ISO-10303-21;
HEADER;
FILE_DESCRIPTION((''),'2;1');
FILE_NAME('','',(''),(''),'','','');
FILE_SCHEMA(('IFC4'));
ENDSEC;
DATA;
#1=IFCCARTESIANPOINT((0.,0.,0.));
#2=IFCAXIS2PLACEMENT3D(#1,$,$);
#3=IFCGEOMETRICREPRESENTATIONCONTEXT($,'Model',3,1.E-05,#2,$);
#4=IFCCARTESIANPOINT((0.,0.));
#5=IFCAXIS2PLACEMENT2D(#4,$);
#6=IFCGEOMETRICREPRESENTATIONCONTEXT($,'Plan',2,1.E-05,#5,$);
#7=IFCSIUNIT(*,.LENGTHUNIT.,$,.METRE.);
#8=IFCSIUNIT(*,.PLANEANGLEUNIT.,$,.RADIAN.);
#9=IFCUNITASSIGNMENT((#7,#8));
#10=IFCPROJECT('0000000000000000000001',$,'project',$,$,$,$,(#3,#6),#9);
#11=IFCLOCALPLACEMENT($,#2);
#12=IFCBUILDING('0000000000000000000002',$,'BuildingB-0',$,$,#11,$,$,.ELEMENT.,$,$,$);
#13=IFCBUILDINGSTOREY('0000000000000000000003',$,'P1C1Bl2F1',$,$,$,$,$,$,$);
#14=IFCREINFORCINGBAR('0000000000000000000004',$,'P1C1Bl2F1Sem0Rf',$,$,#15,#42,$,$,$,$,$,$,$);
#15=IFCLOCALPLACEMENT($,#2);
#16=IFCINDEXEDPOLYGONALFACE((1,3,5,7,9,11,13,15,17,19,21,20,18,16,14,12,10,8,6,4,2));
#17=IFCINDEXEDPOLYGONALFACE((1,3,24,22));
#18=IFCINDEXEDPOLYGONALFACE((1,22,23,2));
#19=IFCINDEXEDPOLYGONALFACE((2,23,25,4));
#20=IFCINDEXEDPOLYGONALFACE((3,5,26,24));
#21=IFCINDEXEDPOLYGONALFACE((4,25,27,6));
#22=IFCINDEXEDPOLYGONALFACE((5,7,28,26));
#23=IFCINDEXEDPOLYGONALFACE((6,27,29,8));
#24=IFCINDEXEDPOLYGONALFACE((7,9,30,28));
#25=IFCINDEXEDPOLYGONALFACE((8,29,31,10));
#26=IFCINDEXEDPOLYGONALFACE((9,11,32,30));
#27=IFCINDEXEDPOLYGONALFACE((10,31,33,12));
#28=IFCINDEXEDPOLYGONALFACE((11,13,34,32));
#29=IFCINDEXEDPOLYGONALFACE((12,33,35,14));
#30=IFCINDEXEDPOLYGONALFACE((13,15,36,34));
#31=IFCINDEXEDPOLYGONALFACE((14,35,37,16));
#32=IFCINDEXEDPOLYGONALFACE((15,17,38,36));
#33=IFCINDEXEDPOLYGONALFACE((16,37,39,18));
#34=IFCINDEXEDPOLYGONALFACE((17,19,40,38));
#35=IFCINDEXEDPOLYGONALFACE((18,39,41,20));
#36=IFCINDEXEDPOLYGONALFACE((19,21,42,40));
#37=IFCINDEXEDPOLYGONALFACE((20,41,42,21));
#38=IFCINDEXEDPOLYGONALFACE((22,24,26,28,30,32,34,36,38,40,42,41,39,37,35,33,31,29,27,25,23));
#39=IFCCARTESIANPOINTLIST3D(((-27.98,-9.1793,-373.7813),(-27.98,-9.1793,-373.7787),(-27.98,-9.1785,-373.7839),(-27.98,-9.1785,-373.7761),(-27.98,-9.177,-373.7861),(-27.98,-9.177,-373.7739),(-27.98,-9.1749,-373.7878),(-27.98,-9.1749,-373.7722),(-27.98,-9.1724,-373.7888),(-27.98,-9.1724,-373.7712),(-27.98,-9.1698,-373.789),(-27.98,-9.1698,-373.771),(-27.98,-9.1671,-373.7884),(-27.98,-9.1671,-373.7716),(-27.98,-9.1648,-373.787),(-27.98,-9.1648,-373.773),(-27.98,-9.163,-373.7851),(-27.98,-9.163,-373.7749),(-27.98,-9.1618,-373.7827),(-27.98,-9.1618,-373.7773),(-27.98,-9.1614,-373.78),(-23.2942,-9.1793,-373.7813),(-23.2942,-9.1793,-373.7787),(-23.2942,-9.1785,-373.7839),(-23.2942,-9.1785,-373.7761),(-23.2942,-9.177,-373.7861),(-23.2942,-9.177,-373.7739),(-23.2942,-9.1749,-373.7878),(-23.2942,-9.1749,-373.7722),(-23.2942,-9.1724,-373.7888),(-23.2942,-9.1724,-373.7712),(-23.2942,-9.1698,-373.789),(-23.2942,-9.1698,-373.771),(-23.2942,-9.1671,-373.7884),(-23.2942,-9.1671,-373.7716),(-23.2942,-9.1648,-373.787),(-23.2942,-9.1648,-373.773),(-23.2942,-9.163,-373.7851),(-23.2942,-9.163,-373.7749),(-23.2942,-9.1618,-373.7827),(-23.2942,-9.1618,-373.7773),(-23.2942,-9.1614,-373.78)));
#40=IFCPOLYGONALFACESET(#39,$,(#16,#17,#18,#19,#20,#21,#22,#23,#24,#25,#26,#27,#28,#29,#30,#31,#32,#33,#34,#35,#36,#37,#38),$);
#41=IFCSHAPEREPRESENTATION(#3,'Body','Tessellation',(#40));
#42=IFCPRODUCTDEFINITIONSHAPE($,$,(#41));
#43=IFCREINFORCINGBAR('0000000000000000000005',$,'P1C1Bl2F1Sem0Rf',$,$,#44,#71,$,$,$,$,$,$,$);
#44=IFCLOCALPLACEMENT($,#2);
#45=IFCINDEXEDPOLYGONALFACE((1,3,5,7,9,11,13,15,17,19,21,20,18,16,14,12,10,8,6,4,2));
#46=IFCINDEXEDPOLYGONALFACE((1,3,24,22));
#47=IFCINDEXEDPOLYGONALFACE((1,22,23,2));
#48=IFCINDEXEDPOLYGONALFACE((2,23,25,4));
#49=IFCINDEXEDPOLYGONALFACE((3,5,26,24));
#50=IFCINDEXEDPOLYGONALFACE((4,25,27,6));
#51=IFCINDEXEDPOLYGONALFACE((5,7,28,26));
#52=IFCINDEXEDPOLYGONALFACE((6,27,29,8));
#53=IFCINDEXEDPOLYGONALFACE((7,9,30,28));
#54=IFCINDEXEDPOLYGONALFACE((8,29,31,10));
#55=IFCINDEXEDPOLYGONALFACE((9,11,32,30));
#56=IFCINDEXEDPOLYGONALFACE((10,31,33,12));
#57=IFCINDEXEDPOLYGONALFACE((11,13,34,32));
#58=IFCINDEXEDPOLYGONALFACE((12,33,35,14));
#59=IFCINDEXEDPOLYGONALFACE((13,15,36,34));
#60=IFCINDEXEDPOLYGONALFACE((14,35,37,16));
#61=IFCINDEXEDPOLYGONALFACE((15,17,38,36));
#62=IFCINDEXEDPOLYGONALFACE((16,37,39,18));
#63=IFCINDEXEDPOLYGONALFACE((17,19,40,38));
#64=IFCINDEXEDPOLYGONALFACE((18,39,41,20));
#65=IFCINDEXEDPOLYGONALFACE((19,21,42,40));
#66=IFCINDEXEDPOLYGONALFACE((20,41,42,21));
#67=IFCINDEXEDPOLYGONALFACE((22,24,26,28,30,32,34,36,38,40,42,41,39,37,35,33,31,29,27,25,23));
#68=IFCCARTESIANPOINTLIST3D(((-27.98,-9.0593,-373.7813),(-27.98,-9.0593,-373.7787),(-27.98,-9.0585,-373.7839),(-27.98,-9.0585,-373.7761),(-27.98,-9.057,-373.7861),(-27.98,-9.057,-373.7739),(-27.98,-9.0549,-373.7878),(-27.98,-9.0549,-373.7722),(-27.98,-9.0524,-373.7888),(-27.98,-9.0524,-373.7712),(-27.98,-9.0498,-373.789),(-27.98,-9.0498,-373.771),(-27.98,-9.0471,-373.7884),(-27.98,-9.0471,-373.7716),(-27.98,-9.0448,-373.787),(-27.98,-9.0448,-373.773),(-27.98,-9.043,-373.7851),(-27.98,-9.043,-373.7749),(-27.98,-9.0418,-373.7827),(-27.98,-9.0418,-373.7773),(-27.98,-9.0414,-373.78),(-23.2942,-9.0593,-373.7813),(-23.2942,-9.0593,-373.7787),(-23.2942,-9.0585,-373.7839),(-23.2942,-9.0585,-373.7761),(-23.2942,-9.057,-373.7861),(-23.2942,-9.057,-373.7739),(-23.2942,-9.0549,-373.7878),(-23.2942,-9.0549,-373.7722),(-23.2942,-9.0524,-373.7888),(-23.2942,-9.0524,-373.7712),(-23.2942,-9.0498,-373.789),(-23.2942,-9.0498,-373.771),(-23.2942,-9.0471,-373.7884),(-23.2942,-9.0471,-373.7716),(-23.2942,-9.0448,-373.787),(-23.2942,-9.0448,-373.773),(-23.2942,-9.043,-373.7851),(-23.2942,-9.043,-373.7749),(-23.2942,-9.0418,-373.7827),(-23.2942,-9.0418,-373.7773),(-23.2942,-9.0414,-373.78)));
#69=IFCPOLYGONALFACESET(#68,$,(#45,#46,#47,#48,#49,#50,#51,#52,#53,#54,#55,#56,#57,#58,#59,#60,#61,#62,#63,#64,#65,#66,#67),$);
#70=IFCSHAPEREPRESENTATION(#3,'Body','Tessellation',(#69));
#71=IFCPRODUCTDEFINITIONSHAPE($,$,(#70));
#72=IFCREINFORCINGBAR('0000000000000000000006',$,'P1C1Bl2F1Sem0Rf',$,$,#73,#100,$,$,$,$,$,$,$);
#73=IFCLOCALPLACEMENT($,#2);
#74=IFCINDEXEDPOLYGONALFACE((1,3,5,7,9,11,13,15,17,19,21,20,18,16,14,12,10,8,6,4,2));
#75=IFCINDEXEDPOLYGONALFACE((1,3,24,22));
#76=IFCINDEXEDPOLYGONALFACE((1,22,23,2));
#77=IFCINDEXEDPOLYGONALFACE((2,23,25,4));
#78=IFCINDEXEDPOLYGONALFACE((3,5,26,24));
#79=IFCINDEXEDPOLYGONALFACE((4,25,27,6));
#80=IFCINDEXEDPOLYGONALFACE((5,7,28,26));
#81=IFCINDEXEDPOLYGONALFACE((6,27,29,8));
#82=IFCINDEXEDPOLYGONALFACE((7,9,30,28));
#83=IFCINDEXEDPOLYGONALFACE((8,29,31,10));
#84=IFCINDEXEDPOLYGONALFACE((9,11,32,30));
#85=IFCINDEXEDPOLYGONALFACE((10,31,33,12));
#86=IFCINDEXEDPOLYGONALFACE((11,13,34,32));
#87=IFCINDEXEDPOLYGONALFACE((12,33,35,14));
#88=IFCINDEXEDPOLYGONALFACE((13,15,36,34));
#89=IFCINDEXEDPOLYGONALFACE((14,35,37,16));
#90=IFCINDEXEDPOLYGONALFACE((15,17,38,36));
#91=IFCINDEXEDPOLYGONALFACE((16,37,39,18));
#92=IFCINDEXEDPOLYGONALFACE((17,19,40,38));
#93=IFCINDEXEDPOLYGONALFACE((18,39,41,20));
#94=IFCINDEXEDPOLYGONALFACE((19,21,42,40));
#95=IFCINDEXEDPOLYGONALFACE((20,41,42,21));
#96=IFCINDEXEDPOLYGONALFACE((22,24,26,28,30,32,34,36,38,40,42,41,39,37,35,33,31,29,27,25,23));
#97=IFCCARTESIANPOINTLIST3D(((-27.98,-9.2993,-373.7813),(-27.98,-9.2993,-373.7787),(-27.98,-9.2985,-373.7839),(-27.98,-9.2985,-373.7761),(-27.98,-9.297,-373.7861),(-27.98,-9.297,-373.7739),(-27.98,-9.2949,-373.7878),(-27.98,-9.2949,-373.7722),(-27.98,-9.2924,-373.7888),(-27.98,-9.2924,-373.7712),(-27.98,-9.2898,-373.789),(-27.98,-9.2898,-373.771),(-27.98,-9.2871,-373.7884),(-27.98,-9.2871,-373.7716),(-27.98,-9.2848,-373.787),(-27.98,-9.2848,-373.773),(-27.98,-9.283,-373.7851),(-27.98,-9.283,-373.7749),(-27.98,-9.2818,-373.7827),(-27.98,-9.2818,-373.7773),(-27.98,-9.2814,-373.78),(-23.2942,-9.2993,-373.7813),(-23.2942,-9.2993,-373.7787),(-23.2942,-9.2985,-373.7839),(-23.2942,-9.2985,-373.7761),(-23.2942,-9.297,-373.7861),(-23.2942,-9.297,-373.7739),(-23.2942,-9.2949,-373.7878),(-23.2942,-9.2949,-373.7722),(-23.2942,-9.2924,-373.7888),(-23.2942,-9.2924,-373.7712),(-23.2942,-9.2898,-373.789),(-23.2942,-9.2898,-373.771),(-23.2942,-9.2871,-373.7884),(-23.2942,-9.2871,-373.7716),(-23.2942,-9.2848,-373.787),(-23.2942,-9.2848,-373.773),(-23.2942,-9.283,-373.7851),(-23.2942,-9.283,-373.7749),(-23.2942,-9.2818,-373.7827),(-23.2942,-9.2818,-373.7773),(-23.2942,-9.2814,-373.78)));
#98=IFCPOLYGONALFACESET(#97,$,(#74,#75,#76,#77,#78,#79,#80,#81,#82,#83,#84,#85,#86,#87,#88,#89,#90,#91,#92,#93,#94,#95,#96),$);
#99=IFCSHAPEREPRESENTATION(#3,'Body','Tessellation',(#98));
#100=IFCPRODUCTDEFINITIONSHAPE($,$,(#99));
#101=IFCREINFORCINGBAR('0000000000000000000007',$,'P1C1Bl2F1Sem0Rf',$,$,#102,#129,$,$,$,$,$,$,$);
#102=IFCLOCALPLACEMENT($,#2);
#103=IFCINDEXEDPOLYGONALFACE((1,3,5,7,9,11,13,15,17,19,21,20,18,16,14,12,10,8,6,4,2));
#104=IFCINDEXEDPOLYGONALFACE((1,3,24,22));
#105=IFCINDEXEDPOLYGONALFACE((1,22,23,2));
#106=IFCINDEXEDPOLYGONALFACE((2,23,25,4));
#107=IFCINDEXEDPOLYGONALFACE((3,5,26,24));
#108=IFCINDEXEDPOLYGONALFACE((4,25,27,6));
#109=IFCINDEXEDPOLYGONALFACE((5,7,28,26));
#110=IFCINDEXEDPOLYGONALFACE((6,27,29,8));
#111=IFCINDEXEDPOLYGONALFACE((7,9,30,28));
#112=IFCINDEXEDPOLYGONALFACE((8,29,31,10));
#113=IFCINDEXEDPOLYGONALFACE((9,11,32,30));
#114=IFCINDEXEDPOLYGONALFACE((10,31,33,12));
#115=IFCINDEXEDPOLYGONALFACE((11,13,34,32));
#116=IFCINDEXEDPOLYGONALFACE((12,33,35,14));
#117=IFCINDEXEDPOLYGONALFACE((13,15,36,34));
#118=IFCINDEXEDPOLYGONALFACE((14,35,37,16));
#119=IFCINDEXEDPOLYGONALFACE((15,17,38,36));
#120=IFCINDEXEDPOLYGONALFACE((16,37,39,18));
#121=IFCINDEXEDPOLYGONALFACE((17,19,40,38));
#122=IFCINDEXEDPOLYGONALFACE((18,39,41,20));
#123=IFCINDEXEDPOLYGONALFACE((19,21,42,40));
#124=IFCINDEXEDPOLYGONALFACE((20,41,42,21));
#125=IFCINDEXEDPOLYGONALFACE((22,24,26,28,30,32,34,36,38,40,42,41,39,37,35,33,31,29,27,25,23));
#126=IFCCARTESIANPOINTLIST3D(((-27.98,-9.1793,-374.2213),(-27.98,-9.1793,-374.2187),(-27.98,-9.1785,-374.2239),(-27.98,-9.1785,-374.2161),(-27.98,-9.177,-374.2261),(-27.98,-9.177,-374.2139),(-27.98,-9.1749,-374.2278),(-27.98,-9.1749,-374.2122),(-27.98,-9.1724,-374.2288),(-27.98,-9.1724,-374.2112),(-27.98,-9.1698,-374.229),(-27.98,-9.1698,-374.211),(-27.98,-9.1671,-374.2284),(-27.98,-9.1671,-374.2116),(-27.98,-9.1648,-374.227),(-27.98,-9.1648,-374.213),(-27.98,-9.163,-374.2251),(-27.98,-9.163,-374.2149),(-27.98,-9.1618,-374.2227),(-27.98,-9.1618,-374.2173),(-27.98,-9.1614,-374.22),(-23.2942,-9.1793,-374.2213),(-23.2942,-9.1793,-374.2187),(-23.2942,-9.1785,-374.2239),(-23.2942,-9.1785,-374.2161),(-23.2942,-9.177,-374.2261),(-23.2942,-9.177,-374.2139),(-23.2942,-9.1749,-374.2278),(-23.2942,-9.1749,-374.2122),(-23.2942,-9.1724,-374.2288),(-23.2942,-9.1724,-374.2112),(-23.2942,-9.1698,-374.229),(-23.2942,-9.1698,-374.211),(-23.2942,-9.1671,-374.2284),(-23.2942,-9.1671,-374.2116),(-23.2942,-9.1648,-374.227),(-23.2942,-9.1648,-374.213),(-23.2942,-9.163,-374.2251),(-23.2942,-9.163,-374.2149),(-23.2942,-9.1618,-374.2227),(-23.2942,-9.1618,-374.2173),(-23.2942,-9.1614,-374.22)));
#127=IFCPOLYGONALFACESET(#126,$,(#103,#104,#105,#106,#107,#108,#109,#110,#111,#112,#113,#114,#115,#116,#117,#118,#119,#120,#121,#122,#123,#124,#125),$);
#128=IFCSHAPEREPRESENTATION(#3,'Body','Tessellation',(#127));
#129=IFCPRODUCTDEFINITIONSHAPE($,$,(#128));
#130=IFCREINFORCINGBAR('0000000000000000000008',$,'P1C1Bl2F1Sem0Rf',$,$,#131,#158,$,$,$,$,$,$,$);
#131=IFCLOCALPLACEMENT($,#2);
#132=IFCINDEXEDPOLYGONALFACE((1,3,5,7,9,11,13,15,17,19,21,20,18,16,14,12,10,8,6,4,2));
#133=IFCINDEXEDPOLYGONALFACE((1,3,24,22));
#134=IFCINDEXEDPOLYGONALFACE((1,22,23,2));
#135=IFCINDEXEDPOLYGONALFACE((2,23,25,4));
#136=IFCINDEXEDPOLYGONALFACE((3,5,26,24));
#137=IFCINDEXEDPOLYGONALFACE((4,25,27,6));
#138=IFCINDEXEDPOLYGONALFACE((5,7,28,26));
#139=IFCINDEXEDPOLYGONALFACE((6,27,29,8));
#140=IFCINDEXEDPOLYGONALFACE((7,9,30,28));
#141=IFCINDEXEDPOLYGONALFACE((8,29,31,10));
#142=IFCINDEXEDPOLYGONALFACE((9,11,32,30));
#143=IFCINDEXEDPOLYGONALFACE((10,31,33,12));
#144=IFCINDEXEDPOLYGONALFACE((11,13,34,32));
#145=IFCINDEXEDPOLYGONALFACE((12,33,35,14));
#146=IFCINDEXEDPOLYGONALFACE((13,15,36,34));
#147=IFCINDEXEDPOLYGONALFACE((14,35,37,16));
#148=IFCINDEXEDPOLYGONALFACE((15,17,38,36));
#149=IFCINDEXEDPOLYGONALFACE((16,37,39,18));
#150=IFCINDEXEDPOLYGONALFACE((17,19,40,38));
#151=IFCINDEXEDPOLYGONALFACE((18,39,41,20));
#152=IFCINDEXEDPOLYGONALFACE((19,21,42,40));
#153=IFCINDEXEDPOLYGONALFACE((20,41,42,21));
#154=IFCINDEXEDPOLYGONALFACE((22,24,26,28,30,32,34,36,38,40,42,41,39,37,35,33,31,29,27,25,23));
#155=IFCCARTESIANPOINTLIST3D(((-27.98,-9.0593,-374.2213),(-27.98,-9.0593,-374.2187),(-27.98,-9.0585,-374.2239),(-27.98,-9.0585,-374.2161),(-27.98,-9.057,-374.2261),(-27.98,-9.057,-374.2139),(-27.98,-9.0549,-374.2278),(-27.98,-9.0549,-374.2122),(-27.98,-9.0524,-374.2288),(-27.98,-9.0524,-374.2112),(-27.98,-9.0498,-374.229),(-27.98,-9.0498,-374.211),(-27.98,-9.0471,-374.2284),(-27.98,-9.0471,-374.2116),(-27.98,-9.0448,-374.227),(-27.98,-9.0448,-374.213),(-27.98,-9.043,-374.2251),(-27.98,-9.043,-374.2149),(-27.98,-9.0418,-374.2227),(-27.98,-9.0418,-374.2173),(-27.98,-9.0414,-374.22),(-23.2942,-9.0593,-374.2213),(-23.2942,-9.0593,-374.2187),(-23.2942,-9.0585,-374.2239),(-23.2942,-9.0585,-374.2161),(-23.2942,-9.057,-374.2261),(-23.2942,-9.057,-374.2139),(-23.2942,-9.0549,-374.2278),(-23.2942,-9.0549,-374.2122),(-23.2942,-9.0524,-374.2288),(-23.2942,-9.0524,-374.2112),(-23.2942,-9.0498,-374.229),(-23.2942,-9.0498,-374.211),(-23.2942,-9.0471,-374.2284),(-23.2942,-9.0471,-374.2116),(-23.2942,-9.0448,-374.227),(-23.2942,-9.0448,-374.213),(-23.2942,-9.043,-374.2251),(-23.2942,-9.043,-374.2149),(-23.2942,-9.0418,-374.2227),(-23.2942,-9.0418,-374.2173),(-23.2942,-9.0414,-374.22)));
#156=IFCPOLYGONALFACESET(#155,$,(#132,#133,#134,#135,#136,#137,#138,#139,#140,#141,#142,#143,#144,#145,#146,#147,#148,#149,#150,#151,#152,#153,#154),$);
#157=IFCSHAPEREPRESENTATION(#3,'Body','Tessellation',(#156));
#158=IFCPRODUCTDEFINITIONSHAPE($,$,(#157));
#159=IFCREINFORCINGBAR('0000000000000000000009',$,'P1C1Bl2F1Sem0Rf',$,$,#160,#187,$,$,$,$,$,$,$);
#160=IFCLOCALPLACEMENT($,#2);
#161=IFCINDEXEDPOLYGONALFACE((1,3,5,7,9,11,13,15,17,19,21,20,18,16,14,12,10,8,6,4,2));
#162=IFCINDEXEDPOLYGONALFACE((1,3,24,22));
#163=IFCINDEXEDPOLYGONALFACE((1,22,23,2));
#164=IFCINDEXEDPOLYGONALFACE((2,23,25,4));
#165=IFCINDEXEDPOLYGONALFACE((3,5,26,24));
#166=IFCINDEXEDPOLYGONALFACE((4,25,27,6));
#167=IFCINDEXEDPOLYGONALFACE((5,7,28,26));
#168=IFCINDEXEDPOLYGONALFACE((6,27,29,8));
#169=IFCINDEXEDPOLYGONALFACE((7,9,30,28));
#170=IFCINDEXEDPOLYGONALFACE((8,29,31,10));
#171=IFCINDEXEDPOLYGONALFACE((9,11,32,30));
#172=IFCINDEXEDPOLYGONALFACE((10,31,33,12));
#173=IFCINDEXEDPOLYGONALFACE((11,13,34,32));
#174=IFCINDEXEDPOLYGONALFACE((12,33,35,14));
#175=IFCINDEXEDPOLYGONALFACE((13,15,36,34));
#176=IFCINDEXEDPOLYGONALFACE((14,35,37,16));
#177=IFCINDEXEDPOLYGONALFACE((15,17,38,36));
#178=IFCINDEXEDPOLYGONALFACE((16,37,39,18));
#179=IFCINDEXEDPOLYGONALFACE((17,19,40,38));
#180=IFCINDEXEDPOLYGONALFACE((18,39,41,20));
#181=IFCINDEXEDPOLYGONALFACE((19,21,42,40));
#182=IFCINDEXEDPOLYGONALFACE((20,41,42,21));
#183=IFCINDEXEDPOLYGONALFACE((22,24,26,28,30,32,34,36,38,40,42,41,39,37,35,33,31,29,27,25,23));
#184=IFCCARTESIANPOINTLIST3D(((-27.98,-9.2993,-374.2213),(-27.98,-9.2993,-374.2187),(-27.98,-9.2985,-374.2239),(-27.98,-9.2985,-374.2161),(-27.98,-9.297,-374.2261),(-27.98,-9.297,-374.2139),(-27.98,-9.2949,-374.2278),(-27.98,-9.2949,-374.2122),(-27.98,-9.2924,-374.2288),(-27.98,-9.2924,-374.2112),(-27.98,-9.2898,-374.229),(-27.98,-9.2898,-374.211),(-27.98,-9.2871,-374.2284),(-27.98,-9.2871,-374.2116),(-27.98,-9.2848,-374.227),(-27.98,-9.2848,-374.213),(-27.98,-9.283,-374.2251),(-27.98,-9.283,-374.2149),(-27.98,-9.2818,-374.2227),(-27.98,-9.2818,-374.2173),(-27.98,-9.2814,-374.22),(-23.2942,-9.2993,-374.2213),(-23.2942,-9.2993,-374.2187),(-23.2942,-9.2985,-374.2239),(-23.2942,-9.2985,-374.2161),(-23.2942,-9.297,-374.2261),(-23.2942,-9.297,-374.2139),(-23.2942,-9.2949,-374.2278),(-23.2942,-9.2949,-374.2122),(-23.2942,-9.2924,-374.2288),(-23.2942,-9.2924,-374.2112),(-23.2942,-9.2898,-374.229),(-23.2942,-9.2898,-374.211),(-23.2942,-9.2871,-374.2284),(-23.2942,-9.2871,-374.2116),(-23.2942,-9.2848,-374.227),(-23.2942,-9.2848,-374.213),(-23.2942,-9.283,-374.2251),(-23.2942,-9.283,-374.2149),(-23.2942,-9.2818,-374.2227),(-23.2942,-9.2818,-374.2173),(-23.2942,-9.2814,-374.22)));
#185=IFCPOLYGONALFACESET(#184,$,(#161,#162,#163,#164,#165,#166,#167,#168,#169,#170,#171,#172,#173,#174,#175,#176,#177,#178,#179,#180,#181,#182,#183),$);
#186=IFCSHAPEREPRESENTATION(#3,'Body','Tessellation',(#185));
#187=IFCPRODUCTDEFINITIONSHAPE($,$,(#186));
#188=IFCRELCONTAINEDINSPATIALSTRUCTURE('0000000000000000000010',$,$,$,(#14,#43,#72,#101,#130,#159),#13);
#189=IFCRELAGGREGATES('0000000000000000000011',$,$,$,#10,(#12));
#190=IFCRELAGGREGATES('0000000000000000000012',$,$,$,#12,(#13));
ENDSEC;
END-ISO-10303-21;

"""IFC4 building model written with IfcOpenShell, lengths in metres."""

from ifc_helpers import new_model, entity, si_unit, origin, origin_2d, place, context, project, spatial, element, save


model = new_model("IFC4")

# Units and contexts
model_context = context("Model", 3, precision=1e-05, world=origin())
plan_context = context("Plan", 2, precision=1e-05, world=origin_2d())
ifc_project = project(units=[si_unit("LENGTHUNIT", "METRE"), si_unit("PLANEANGLEUNIT", "RADIAN")], contexts=[model_context, plan_context])

# Building, storey
building_placement = place(None, origin())
building = spatial("IfcBuilding", under=ifc_project, at=building_placement, Name="BuildingB-0", CompositionType="ELEMENT")
storey = spatial("IfcBuildingStorey", under=building, Name="P1C1Bl2F1")

# Reinforcing bars
element("IfcReinforcingBar", 1, inside=storey, Name="P1C1Bl2F1Sem0Rf", context=model_context, shape_type="SweptSolid", body=[
    entity("IfcSurfaceCurveSweptAreaSolid", entity("IfcCircleProfileDef", "AREA", None, None, 0.009), None, entity("IfcPolyline", [entity("IfcCartesianPoint", [23.2942, 9.1704, 373.78]), entity("IfcCartesianPoint", [27.98, 9.1704, 373.78])]), None, None, entity("IfcPlane", entity("IfcAxis2Placement3D", entity("IfcCartesianPoint", [23.2942, 9.1704, 373.78]), entity("IfcDirection", [0.0, 0.0, 1.0]), entity("IfcDirection", [1.0, 0.0, 0.0])))),
])
element("IfcReinforcingBar", 2, inside=storey, Name="P1C1Bl2F1Sem0Rf", context=model_context, shape_type="SweptSolid", body=[
    entity("IfcSurfaceCurveSweptAreaSolid", entity("IfcCircleProfileDef", "AREA", None, None, 0.009), None, entity("IfcPolyline", [entity("IfcCartesianPoint", [23.2942, 9.0504, 373.78]), entity("IfcCartesianPoint", [27.98, 9.0504, 373.78])]), None, None, entity("IfcPlane", entity("IfcAxis2Placement3D", entity("IfcCartesianPoint", [23.2942, 9.0504, 373.78]), entity("IfcDirection", [0.0, 0.0, 1.0]), entity("IfcDirection", [1.0, 0.0, 0.0])))),
])
element("IfcReinforcingBar", 3, inside=storey, Name="P1C1Bl2F1Sem0Rf", context=model_context, shape_type="SweptSolid", body=[
    entity("IfcSurfaceCurveSweptAreaSolid", entity("IfcCircleProfileDef", "AREA", None, None, 0.009), None, entity("IfcPolyline", [entity("IfcCartesianPoint", [23.2942, 9.2904, 373.78]), entity("IfcCartesianPoint", [27.98, 9.2904, 373.78])]), None, None, entity("IfcPlane", entity("IfcAxis2Placement3D", entity("IfcCartesianPoint", [23.2942, 9.2904, 373.78]), entity("IfcDirection", [0.0, 0.0, 1.0]), entity("IfcDirection", [1.0, 0.0, 0.0])))),
])
element("IfcReinforcingBar", 4, inside=storey, Name="P1C1Bl2F1Sem0Rf", context=model_context, shape_type="SweptSolid", body=[
    entity("IfcSurfaceCurveSweptAreaSolid", entity("IfcCircleProfileDef", "AREA", None, None, 0.009), None, entity("IfcPolyline", [entity("IfcCartesianPoint", [23.2942, 9.1704, 374.22]), entity("IfcCartesianPoint", [27.98, 9.1704, 374.22])]), None, None, entity("IfcPlane", entity("IfcAxis2Placement3D", entity("IfcCartesianPoint", [23.2942, 9.1704, 374.22]), entity("IfcDirection", [0.0, 0.0, 1.0]), entity("IfcDirection", [1.0, 0.0, 0.0])))),
])
element("IfcReinforcingBar", 5, inside=storey, Name="P1C1Bl2F1Sem0Rf", context=model_context, shape_type="SweptSolid", body=[
    entity("IfcSurfaceCurveSweptAreaSolid", entity("IfcCircleProfileDef", "AREA", None, None, 0.009), None, entity("IfcPolyline", [entity("IfcCartesianPoint", [23.2942, 9.0504, 374.22]), entity("IfcCartesianPoint", [27.98, 9.0504, 374.22])]), None, None, entity("IfcPlane", entity("IfcAxis2Placement3D", entity("IfcCartesianPoint", [23.2942, 9.0504, 374.22]), entity("IfcDirection", [0.0, 0.0, 1.0]), entity("IfcDirection", [1.0, 0.0, 0.0])))),
])
element("IfcReinforcingBar", 6, inside=storey, Name="P1C1Bl2F1Sem0Rf", context=model_context, shape_type="SweptSolid", body=[
    entity("IfcSurfaceCurveSweptAreaSolid", entity("IfcCircleProfileDef", "AREA", None, None, 0.009), None, entity("IfcPolyline", [entity("IfcCartesianPoint", [23.2942, 9.2904, 374.22]), entity("IfcCartesianPoint", [27.98, 9.2904, 374.22])]), None, None, entity("IfcPlane", entity("IfcAxis2Placement3D", entity("IfcCartesianPoint", [23.2942, 9.2904, 374.22]), entity("IfcDirection", [0.0, 0.0, 1.0]), entity("IfcDirection", [1.0, 0.0, 0.0])))),
])

save(model, "model.ifc")
